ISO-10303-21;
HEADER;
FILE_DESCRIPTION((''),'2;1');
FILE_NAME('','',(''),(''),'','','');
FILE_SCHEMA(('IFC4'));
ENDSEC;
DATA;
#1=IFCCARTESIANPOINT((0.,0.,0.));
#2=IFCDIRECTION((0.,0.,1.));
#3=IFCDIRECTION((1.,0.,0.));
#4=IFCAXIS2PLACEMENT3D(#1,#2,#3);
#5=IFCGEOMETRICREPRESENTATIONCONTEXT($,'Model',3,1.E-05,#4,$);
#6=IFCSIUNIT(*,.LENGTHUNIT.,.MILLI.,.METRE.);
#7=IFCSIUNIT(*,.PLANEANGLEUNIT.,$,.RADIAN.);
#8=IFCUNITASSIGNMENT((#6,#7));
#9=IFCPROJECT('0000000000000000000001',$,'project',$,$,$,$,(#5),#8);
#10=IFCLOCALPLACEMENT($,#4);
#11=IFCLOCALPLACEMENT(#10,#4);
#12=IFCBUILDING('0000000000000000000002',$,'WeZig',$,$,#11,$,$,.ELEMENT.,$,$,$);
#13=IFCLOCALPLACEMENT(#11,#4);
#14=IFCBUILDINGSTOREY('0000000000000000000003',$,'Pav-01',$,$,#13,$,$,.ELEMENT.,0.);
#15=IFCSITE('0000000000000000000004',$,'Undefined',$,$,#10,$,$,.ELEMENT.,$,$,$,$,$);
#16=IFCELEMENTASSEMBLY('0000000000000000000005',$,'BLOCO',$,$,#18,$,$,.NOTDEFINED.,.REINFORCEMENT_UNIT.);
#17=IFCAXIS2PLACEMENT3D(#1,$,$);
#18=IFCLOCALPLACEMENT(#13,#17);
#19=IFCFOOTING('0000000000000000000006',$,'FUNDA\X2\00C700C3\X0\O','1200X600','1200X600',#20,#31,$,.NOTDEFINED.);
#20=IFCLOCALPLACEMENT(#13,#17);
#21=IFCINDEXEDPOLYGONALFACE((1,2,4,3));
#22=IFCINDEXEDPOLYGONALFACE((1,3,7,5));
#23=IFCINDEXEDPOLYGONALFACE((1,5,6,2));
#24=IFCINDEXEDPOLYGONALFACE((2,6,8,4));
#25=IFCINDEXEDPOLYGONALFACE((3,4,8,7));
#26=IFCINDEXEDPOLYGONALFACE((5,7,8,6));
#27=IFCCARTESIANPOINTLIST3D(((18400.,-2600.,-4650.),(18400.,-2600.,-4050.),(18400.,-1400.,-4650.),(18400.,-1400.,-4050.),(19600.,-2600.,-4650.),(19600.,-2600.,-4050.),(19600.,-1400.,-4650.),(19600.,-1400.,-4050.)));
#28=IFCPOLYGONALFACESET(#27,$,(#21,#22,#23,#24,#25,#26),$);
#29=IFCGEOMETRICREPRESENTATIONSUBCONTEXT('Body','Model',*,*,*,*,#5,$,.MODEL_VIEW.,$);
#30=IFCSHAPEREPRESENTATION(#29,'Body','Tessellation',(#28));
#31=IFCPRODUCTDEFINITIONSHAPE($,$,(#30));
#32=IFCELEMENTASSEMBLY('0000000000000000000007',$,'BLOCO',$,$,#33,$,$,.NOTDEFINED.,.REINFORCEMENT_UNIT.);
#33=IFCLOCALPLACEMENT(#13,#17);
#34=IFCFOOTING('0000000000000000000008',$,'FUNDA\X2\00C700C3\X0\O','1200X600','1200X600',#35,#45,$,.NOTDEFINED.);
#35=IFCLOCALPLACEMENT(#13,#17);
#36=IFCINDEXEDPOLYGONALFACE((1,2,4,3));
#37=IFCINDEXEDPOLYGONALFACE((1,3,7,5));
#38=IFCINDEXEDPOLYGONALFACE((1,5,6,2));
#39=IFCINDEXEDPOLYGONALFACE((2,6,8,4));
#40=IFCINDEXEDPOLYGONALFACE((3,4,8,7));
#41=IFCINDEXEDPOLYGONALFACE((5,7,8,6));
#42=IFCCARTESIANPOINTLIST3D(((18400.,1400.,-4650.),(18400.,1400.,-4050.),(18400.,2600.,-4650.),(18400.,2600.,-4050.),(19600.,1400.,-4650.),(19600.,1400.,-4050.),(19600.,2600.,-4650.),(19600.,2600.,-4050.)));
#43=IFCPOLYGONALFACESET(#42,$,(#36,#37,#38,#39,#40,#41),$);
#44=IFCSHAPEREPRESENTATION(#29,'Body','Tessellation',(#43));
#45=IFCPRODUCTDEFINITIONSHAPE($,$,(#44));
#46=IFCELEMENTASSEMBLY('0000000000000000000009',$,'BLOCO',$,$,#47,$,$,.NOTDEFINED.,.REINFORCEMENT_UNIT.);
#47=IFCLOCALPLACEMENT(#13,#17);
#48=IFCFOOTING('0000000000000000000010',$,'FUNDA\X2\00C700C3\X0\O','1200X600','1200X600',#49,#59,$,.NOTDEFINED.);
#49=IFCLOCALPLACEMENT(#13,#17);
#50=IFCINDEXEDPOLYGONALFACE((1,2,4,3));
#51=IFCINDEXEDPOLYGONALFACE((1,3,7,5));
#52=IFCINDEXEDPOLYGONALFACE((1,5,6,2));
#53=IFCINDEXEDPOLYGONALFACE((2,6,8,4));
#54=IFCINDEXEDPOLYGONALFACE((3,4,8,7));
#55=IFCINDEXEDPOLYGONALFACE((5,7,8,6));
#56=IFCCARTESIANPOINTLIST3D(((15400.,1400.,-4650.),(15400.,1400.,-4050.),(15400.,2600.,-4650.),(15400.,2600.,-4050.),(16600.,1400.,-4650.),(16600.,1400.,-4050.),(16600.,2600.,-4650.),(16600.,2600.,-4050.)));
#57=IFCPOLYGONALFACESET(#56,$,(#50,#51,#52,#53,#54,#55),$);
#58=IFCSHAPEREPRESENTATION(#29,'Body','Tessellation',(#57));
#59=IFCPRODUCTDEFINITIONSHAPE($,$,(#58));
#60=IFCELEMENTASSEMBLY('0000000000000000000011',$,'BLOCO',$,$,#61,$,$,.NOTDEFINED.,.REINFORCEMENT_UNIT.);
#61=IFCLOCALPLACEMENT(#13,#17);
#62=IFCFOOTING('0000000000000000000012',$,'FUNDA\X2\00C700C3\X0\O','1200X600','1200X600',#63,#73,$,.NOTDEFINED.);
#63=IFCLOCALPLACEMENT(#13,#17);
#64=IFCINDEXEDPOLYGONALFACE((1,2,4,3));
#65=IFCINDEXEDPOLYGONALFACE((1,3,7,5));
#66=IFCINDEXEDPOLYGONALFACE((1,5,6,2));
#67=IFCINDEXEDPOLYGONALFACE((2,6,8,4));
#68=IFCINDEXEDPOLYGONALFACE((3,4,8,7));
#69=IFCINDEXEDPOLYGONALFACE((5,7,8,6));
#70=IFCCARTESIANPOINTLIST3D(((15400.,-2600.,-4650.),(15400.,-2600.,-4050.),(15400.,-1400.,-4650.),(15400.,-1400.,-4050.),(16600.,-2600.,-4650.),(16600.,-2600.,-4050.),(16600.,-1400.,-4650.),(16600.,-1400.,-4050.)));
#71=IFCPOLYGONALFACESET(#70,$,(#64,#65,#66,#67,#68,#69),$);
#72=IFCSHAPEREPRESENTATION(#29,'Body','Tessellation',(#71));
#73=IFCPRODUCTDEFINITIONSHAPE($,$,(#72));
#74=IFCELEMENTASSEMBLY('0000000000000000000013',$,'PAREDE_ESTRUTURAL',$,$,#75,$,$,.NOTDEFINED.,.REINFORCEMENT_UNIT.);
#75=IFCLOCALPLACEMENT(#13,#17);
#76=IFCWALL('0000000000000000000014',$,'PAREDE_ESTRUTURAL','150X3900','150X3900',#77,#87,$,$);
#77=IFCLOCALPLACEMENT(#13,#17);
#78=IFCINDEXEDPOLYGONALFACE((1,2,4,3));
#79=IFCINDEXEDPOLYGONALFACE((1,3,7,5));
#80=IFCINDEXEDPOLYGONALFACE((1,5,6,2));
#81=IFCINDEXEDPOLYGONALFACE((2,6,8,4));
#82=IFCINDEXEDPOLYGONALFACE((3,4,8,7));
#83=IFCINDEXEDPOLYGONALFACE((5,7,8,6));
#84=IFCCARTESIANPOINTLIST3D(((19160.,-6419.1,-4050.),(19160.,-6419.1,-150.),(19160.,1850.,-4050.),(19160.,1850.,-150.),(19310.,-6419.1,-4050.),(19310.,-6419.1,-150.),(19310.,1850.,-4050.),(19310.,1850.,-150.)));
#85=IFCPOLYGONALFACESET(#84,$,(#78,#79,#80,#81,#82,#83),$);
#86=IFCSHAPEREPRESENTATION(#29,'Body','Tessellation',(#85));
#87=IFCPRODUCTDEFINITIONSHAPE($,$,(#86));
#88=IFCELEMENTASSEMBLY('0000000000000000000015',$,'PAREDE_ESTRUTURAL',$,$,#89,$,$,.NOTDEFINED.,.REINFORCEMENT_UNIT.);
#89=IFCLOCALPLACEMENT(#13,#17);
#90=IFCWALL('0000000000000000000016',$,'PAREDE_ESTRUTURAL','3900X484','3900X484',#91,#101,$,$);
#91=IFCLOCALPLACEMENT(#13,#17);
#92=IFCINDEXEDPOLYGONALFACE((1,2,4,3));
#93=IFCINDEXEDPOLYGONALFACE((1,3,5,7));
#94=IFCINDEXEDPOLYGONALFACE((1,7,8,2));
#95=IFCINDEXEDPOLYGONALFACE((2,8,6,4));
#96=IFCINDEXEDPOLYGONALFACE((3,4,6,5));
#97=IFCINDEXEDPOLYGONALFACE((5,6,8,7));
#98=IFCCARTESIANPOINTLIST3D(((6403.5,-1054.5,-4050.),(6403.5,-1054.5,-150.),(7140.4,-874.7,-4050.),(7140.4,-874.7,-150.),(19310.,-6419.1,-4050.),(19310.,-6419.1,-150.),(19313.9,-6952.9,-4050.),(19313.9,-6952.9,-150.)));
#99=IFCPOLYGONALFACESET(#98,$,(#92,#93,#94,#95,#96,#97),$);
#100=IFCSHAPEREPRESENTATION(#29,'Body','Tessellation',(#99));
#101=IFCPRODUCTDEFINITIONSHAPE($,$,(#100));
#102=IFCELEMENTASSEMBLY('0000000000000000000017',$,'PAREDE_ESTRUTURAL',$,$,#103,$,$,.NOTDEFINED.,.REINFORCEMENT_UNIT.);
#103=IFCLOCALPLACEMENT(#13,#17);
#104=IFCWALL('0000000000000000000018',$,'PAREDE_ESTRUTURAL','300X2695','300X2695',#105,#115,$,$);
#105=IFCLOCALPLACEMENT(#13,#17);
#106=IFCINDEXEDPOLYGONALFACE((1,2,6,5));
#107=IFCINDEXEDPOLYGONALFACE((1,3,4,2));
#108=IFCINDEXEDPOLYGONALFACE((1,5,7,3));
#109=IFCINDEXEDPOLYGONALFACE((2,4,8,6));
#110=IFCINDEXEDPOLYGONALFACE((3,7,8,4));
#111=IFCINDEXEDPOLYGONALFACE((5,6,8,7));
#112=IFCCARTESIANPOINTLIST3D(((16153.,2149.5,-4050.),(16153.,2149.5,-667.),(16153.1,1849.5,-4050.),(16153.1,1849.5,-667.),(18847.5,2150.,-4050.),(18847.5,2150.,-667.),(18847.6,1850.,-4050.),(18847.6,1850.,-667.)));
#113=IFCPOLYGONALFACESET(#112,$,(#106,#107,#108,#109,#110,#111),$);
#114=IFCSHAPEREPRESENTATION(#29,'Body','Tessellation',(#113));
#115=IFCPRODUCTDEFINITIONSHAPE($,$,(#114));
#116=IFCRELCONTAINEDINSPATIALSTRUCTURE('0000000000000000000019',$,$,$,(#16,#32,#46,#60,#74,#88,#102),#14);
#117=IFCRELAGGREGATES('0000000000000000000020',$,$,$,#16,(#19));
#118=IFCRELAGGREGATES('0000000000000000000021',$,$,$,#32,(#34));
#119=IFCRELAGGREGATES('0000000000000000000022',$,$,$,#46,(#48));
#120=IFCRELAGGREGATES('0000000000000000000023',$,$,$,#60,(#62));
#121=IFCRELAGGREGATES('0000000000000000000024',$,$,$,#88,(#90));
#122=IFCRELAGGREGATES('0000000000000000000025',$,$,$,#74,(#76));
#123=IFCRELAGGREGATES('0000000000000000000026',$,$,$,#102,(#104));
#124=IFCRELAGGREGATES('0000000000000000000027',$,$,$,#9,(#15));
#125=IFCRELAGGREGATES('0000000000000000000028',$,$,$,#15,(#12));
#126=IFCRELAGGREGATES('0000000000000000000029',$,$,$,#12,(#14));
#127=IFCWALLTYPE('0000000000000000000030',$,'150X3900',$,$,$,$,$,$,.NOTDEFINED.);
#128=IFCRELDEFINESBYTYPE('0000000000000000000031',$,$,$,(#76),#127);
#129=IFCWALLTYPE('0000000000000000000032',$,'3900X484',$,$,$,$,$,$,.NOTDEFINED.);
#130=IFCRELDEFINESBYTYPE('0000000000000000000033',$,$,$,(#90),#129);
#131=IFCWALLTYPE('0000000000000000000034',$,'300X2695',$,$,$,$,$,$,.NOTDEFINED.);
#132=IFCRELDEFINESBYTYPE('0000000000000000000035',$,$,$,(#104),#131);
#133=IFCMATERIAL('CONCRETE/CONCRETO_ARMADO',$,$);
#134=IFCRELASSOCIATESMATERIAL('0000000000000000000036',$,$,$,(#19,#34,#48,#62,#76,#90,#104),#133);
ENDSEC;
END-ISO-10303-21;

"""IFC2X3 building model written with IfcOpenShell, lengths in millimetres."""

from ifc_helpers import new_model, si_unit, frame, frame_2d, origin_with_axes, origin_2d_with_axis, place, context, subcontext, project, spatial, polyline, rectangle, outline, extrude, material, type_object, element, aggregate, save


model = new_model("IFC2X3")

# Units and contexts
model_context = context("Model", 3, precision=1e-05, world=origin_with_axes())
body_context = subcontext(model_context, "Body", "Model", "MODEL_VIEW")
ifc_project = project(units=[si_unit("LENGTHUNIT", "METRE", prefix="MILLI"), si_unit("PLANEANGLEUNIT", "RADIAN")], contexts=[model_context])

# Site, building, storey
site_placement = place(None, origin_with_axes())
site = spatial("IfcSite", under=ifc_project, at=site_placement, Name="Undefined", CompositionType="ELEMENT")
building_placement = place(site_placement, origin_with_axes())
building = spatial("IfcBuilding", under=site, at=building_placement, Name="WeZig", CompositionType="ELEMENT")
storey_placement = place(building_placement, origin_with_axes())
storey = spatial("IfcBuildingStorey", under=building, at=storey_placement, Name="Pav-01", CompositionType="ELEMENT", Elevation=0.0)

# Element assemblies, footings
assembly_1_placement = place(storey_placement, origin_with_axes())
assembly_1 = element("IfcElementAssembly", 1, at=assembly_1_placement, inside=storey, Name="BLOCO", AssemblyPlace="NOTDEFINED", PredefinedType="REINFORCEMENT_UNIT")
ifc_material_1 = material(Name="CONCRETE/CONCRETO_ARMADO")
footing_1_placement = place(assembly_1_placement, frame((19000.0, -2000.0, -4650.0), z_axis=(0.0, 1.0, 0.0), x_axis=(0.0, 0.0, 1.0)))
footing_1 = element("IfcFooting", 2, at=footing_1_placement, material=ifc_material_1, Name="FUNDAÇÃO", Description="1200X600", ObjectType="1200X600", PredefinedType="NOTDEFINED", context=body_context, shape_type="SweptSolid", body=[
    extrude(rectangle(XDim=1200.0, YDim=1200.0, at=origin_2d_with_axis()), frame((600.0, 0.0, 0.0), z_axis=(-1.0, 0.0, 0.0), x_axis=(0.0, -1.0, 0.0)), (0.0, 0.0, 1.0), 600.0),
])
aggregate(assembly_1, [footing_1])
assembly_2_placement = place(storey_placement, origin_with_axes())
assembly_2 = element("IfcElementAssembly", 3, at=assembly_2_placement, inside=storey, Name="BLOCO", AssemblyPlace="NOTDEFINED", PredefinedType="REINFORCEMENT_UNIT")
footing_2_placement = place(assembly_2_placement, frame((19000.0, 2000.0, -4650.0), z_axis=(0.0, 1.0, 0.0), x_axis=(0.0, 0.0, 1.0)))
footing_2 = element("IfcFooting", 4, at=footing_2_placement, material=ifc_material_1, Name="FUNDAÇÃO", Description="1200X600", ObjectType="1200X600", PredefinedType="NOTDEFINED", context=body_context, shape_type="SweptSolid", body=[
    extrude(rectangle(XDim=1200.0, YDim=1200.0, at=origin_2d_with_axis()), frame((600.0, 0.0, 0.0), z_axis=(-1.0, 0.0, 0.0), x_axis=(0.0, -1.0, 0.0)), (0.0, 0.0, 1.0), 600.0),
])
aggregate(assembly_2, [footing_2])
assembly_3_placement = place(storey_placement, origin_with_axes())
assembly_3 = element("IfcElementAssembly", 5, at=assembly_3_placement, inside=storey, Name="BLOCO", AssemblyPlace="NOTDEFINED", PredefinedType="REINFORCEMENT_UNIT")
footing_3_placement = place(assembly_3_placement, frame((16000.0, 2000.0, -4650.0), z_axis=(0.0, 1.0, 0.0), x_axis=(0.0, 0.0, 1.0)))
footing_3 = element("IfcFooting", 6, at=footing_3_placement, material=ifc_material_1, Name="FUNDAÇÃO", Description="1200X600", ObjectType="1200X600", PredefinedType="NOTDEFINED", context=body_context, shape_type="SweptSolid", body=[
    extrude(rectangle(XDim=1200.0, YDim=1200.0, at=origin_2d_with_axis()), frame((600.0, 0.0, 0.0), z_axis=(-1.0, 0.0, 0.0), x_axis=(0.0, -1.0, 0.0)), (0.0, 0.0, 1.0), 600.0),
])
aggregate(assembly_3, [footing_3])
assembly_4_placement = place(storey_placement, origin_with_axes())
assembly_4 = element("IfcElementAssembly", 7, at=assembly_4_placement, inside=storey, Name="BLOCO", AssemblyPlace="NOTDEFINED", PredefinedType="REINFORCEMENT_UNIT")
footing_4_placement = place(assembly_4_placement, frame((16000.0, -2000.0, -4650.0), z_axis=(0.0, 1.0, 0.0), x_axis=(0.0, 0.0, 1.0)))
footing_4 = element("IfcFooting", 8, at=footing_4_placement, material=ifc_material_1, Name="FUNDAÇÃO", Description="1200X600", ObjectType="1200X600", PredefinedType="NOTDEFINED", context=body_context, shape_type="SweptSolid", body=[
    extrude(rectangle(XDim=1200.0, YDim=1200.0, at=origin_2d_with_axis()), frame((600.0, 0.0, 0.0), z_axis=(-1.0, 0.0, 0.0), x_axis=(0.0, -1.0, 0.0)), (0.0, 0.0, 1.0), 600.0),
])
aggregate(assembly_4, [footing_4])

# Element assemblies, walls
assembly_5_placement = place(storey_placement, origin_with_axes())
assembly_5 = element("IfcElementAssembly", 9, at=assembly_5_placement, inside=storey, Name="PAREDE_ESTRUTURAL", AssemblyPlace="NOTDEFINED", PredefinedType="REINFORCEMENT_UNIT")
wall_type_1 = type_object("IfcWallType", Name="150X3900", PredefinedType="NOTDEFINED")
wall_1_placement = place(assembly_5_placement, frame((19235.0, 1850.0, -4050.0), z_axis=(0.0, 0.0, 1.0), x_axis=(-0.000004, -1.0, 0.0)))
wall_1 = element("IfcWall", 10, at=wall_1_placement, type_object=wall_type_1, material=ifc_material_1, Name="PAREDE_ESTRUTURAL", Description="150X3900", ObjectType="150X3900", context=body_context, shape_type="SweptSolid", body=[
    extrude(rectangle(XDim=8269.1, YDim=150.0, at=frame_2d((0.0, 4134.5), x_axis=(0.0, -1.0))), frame((0.0, 0.0, 0.0), z_axis=(0.0, 0.0, 1.0), x_axis=(0.0, -1.0, 0.0)), (0.0, 0.0, 1.0), 3900.0),
])
assembly_6_placement = place(storey_placement, origin_with_axes())
assembly_6 = element("IfcElementAssembly", 11, at=assembly_6_placement, inside=storey, Name="PAREDE_ESTRUTURAL", AssemblyPlace="NOTDEFINED", PredefinedType="REINFORCEMENT_UNIT")
wall_type_2 = type_object("IfcWallType", Name="3900X484", PredefinedType="NOTDEFINED")
wall_2_placement = place(assembly_6_placement, frame((19310.0, -6419.1, -2100.0), z_axis=(0.0, 0.0, 1.0), x_axis=(-0.910005, 0.414596, 0.0)))
wall_2 = element("IfcWall", 12, at=wall_2_placement, type_object=wall_type_2, material=ifc_material_1, Name="PAREDE_ESTRUTURAL", Description="3900X484", ObjectType="3900X484", context=body_context, shape_type="SweptSolid", body=[
    extrude(outline(polyline([(0.0, 0.0), (13373.1, 0.0), (13969.1, 469.2), (-224.8, 484.1), (0.0, 0.0)])), frame((0.0, 0.0, -1950.0), z_axis=(0.0, 0.0, 1.0), x_axis=(1.0, 0.0, 0.0)), (0.0, 0.0, 1.0), 3900.0),
])
assembly_7_placement = place(storey_placement, origin_with_axes())
assembly_7 = element("IfcElementAssembly", 13, at=assembly_7_placement, inside=storey, Name="PAREDE_ESTRUTURAL", AssemblyPlace="NOTDEFINED", PredefinedType="REINFORCEMENT_UNIT")
wall_type_3 = type_object("IfcWallType", Name="300X2695", PredefinedType="NOTDEFINED")
wall_3_placement = place(assembly_7_placement, frame((18847.5, 2000.0, -3705.8), z_axis=(0.0, 0.0, 1.0), x_axis=(-1.0, -0.000186, 0.0)))
wall_3 = element("IfcWall", 14, at=wall_3_placement, type_object=wall_type_3, material=ifc_material_1, Name="PAREDE_ESTRUTURAL", Description="300X2695", ObjectType="300X2695", context=body_context, shape_type="SweptSolid", body=[
    extrude(rectangle(XDim=2694.5, YDim=300.0, at=frame_2d((0.0, 1347.3), x_axis=(0.0, -1.0))), frame((0.0, 0.0, -344.2), z_axis=(0.0, 0.0, 1.0), x_axis=(0.0, -1.0, 0.0)), (0.0, 0.0, 1.0), 3383.0),
])

aggregate(assembly_6, [wall_2])
aggregate(assembly_5, [wall_1])
aggregate(assembly_7, [wall_3])

save(model, "model.ifc")
